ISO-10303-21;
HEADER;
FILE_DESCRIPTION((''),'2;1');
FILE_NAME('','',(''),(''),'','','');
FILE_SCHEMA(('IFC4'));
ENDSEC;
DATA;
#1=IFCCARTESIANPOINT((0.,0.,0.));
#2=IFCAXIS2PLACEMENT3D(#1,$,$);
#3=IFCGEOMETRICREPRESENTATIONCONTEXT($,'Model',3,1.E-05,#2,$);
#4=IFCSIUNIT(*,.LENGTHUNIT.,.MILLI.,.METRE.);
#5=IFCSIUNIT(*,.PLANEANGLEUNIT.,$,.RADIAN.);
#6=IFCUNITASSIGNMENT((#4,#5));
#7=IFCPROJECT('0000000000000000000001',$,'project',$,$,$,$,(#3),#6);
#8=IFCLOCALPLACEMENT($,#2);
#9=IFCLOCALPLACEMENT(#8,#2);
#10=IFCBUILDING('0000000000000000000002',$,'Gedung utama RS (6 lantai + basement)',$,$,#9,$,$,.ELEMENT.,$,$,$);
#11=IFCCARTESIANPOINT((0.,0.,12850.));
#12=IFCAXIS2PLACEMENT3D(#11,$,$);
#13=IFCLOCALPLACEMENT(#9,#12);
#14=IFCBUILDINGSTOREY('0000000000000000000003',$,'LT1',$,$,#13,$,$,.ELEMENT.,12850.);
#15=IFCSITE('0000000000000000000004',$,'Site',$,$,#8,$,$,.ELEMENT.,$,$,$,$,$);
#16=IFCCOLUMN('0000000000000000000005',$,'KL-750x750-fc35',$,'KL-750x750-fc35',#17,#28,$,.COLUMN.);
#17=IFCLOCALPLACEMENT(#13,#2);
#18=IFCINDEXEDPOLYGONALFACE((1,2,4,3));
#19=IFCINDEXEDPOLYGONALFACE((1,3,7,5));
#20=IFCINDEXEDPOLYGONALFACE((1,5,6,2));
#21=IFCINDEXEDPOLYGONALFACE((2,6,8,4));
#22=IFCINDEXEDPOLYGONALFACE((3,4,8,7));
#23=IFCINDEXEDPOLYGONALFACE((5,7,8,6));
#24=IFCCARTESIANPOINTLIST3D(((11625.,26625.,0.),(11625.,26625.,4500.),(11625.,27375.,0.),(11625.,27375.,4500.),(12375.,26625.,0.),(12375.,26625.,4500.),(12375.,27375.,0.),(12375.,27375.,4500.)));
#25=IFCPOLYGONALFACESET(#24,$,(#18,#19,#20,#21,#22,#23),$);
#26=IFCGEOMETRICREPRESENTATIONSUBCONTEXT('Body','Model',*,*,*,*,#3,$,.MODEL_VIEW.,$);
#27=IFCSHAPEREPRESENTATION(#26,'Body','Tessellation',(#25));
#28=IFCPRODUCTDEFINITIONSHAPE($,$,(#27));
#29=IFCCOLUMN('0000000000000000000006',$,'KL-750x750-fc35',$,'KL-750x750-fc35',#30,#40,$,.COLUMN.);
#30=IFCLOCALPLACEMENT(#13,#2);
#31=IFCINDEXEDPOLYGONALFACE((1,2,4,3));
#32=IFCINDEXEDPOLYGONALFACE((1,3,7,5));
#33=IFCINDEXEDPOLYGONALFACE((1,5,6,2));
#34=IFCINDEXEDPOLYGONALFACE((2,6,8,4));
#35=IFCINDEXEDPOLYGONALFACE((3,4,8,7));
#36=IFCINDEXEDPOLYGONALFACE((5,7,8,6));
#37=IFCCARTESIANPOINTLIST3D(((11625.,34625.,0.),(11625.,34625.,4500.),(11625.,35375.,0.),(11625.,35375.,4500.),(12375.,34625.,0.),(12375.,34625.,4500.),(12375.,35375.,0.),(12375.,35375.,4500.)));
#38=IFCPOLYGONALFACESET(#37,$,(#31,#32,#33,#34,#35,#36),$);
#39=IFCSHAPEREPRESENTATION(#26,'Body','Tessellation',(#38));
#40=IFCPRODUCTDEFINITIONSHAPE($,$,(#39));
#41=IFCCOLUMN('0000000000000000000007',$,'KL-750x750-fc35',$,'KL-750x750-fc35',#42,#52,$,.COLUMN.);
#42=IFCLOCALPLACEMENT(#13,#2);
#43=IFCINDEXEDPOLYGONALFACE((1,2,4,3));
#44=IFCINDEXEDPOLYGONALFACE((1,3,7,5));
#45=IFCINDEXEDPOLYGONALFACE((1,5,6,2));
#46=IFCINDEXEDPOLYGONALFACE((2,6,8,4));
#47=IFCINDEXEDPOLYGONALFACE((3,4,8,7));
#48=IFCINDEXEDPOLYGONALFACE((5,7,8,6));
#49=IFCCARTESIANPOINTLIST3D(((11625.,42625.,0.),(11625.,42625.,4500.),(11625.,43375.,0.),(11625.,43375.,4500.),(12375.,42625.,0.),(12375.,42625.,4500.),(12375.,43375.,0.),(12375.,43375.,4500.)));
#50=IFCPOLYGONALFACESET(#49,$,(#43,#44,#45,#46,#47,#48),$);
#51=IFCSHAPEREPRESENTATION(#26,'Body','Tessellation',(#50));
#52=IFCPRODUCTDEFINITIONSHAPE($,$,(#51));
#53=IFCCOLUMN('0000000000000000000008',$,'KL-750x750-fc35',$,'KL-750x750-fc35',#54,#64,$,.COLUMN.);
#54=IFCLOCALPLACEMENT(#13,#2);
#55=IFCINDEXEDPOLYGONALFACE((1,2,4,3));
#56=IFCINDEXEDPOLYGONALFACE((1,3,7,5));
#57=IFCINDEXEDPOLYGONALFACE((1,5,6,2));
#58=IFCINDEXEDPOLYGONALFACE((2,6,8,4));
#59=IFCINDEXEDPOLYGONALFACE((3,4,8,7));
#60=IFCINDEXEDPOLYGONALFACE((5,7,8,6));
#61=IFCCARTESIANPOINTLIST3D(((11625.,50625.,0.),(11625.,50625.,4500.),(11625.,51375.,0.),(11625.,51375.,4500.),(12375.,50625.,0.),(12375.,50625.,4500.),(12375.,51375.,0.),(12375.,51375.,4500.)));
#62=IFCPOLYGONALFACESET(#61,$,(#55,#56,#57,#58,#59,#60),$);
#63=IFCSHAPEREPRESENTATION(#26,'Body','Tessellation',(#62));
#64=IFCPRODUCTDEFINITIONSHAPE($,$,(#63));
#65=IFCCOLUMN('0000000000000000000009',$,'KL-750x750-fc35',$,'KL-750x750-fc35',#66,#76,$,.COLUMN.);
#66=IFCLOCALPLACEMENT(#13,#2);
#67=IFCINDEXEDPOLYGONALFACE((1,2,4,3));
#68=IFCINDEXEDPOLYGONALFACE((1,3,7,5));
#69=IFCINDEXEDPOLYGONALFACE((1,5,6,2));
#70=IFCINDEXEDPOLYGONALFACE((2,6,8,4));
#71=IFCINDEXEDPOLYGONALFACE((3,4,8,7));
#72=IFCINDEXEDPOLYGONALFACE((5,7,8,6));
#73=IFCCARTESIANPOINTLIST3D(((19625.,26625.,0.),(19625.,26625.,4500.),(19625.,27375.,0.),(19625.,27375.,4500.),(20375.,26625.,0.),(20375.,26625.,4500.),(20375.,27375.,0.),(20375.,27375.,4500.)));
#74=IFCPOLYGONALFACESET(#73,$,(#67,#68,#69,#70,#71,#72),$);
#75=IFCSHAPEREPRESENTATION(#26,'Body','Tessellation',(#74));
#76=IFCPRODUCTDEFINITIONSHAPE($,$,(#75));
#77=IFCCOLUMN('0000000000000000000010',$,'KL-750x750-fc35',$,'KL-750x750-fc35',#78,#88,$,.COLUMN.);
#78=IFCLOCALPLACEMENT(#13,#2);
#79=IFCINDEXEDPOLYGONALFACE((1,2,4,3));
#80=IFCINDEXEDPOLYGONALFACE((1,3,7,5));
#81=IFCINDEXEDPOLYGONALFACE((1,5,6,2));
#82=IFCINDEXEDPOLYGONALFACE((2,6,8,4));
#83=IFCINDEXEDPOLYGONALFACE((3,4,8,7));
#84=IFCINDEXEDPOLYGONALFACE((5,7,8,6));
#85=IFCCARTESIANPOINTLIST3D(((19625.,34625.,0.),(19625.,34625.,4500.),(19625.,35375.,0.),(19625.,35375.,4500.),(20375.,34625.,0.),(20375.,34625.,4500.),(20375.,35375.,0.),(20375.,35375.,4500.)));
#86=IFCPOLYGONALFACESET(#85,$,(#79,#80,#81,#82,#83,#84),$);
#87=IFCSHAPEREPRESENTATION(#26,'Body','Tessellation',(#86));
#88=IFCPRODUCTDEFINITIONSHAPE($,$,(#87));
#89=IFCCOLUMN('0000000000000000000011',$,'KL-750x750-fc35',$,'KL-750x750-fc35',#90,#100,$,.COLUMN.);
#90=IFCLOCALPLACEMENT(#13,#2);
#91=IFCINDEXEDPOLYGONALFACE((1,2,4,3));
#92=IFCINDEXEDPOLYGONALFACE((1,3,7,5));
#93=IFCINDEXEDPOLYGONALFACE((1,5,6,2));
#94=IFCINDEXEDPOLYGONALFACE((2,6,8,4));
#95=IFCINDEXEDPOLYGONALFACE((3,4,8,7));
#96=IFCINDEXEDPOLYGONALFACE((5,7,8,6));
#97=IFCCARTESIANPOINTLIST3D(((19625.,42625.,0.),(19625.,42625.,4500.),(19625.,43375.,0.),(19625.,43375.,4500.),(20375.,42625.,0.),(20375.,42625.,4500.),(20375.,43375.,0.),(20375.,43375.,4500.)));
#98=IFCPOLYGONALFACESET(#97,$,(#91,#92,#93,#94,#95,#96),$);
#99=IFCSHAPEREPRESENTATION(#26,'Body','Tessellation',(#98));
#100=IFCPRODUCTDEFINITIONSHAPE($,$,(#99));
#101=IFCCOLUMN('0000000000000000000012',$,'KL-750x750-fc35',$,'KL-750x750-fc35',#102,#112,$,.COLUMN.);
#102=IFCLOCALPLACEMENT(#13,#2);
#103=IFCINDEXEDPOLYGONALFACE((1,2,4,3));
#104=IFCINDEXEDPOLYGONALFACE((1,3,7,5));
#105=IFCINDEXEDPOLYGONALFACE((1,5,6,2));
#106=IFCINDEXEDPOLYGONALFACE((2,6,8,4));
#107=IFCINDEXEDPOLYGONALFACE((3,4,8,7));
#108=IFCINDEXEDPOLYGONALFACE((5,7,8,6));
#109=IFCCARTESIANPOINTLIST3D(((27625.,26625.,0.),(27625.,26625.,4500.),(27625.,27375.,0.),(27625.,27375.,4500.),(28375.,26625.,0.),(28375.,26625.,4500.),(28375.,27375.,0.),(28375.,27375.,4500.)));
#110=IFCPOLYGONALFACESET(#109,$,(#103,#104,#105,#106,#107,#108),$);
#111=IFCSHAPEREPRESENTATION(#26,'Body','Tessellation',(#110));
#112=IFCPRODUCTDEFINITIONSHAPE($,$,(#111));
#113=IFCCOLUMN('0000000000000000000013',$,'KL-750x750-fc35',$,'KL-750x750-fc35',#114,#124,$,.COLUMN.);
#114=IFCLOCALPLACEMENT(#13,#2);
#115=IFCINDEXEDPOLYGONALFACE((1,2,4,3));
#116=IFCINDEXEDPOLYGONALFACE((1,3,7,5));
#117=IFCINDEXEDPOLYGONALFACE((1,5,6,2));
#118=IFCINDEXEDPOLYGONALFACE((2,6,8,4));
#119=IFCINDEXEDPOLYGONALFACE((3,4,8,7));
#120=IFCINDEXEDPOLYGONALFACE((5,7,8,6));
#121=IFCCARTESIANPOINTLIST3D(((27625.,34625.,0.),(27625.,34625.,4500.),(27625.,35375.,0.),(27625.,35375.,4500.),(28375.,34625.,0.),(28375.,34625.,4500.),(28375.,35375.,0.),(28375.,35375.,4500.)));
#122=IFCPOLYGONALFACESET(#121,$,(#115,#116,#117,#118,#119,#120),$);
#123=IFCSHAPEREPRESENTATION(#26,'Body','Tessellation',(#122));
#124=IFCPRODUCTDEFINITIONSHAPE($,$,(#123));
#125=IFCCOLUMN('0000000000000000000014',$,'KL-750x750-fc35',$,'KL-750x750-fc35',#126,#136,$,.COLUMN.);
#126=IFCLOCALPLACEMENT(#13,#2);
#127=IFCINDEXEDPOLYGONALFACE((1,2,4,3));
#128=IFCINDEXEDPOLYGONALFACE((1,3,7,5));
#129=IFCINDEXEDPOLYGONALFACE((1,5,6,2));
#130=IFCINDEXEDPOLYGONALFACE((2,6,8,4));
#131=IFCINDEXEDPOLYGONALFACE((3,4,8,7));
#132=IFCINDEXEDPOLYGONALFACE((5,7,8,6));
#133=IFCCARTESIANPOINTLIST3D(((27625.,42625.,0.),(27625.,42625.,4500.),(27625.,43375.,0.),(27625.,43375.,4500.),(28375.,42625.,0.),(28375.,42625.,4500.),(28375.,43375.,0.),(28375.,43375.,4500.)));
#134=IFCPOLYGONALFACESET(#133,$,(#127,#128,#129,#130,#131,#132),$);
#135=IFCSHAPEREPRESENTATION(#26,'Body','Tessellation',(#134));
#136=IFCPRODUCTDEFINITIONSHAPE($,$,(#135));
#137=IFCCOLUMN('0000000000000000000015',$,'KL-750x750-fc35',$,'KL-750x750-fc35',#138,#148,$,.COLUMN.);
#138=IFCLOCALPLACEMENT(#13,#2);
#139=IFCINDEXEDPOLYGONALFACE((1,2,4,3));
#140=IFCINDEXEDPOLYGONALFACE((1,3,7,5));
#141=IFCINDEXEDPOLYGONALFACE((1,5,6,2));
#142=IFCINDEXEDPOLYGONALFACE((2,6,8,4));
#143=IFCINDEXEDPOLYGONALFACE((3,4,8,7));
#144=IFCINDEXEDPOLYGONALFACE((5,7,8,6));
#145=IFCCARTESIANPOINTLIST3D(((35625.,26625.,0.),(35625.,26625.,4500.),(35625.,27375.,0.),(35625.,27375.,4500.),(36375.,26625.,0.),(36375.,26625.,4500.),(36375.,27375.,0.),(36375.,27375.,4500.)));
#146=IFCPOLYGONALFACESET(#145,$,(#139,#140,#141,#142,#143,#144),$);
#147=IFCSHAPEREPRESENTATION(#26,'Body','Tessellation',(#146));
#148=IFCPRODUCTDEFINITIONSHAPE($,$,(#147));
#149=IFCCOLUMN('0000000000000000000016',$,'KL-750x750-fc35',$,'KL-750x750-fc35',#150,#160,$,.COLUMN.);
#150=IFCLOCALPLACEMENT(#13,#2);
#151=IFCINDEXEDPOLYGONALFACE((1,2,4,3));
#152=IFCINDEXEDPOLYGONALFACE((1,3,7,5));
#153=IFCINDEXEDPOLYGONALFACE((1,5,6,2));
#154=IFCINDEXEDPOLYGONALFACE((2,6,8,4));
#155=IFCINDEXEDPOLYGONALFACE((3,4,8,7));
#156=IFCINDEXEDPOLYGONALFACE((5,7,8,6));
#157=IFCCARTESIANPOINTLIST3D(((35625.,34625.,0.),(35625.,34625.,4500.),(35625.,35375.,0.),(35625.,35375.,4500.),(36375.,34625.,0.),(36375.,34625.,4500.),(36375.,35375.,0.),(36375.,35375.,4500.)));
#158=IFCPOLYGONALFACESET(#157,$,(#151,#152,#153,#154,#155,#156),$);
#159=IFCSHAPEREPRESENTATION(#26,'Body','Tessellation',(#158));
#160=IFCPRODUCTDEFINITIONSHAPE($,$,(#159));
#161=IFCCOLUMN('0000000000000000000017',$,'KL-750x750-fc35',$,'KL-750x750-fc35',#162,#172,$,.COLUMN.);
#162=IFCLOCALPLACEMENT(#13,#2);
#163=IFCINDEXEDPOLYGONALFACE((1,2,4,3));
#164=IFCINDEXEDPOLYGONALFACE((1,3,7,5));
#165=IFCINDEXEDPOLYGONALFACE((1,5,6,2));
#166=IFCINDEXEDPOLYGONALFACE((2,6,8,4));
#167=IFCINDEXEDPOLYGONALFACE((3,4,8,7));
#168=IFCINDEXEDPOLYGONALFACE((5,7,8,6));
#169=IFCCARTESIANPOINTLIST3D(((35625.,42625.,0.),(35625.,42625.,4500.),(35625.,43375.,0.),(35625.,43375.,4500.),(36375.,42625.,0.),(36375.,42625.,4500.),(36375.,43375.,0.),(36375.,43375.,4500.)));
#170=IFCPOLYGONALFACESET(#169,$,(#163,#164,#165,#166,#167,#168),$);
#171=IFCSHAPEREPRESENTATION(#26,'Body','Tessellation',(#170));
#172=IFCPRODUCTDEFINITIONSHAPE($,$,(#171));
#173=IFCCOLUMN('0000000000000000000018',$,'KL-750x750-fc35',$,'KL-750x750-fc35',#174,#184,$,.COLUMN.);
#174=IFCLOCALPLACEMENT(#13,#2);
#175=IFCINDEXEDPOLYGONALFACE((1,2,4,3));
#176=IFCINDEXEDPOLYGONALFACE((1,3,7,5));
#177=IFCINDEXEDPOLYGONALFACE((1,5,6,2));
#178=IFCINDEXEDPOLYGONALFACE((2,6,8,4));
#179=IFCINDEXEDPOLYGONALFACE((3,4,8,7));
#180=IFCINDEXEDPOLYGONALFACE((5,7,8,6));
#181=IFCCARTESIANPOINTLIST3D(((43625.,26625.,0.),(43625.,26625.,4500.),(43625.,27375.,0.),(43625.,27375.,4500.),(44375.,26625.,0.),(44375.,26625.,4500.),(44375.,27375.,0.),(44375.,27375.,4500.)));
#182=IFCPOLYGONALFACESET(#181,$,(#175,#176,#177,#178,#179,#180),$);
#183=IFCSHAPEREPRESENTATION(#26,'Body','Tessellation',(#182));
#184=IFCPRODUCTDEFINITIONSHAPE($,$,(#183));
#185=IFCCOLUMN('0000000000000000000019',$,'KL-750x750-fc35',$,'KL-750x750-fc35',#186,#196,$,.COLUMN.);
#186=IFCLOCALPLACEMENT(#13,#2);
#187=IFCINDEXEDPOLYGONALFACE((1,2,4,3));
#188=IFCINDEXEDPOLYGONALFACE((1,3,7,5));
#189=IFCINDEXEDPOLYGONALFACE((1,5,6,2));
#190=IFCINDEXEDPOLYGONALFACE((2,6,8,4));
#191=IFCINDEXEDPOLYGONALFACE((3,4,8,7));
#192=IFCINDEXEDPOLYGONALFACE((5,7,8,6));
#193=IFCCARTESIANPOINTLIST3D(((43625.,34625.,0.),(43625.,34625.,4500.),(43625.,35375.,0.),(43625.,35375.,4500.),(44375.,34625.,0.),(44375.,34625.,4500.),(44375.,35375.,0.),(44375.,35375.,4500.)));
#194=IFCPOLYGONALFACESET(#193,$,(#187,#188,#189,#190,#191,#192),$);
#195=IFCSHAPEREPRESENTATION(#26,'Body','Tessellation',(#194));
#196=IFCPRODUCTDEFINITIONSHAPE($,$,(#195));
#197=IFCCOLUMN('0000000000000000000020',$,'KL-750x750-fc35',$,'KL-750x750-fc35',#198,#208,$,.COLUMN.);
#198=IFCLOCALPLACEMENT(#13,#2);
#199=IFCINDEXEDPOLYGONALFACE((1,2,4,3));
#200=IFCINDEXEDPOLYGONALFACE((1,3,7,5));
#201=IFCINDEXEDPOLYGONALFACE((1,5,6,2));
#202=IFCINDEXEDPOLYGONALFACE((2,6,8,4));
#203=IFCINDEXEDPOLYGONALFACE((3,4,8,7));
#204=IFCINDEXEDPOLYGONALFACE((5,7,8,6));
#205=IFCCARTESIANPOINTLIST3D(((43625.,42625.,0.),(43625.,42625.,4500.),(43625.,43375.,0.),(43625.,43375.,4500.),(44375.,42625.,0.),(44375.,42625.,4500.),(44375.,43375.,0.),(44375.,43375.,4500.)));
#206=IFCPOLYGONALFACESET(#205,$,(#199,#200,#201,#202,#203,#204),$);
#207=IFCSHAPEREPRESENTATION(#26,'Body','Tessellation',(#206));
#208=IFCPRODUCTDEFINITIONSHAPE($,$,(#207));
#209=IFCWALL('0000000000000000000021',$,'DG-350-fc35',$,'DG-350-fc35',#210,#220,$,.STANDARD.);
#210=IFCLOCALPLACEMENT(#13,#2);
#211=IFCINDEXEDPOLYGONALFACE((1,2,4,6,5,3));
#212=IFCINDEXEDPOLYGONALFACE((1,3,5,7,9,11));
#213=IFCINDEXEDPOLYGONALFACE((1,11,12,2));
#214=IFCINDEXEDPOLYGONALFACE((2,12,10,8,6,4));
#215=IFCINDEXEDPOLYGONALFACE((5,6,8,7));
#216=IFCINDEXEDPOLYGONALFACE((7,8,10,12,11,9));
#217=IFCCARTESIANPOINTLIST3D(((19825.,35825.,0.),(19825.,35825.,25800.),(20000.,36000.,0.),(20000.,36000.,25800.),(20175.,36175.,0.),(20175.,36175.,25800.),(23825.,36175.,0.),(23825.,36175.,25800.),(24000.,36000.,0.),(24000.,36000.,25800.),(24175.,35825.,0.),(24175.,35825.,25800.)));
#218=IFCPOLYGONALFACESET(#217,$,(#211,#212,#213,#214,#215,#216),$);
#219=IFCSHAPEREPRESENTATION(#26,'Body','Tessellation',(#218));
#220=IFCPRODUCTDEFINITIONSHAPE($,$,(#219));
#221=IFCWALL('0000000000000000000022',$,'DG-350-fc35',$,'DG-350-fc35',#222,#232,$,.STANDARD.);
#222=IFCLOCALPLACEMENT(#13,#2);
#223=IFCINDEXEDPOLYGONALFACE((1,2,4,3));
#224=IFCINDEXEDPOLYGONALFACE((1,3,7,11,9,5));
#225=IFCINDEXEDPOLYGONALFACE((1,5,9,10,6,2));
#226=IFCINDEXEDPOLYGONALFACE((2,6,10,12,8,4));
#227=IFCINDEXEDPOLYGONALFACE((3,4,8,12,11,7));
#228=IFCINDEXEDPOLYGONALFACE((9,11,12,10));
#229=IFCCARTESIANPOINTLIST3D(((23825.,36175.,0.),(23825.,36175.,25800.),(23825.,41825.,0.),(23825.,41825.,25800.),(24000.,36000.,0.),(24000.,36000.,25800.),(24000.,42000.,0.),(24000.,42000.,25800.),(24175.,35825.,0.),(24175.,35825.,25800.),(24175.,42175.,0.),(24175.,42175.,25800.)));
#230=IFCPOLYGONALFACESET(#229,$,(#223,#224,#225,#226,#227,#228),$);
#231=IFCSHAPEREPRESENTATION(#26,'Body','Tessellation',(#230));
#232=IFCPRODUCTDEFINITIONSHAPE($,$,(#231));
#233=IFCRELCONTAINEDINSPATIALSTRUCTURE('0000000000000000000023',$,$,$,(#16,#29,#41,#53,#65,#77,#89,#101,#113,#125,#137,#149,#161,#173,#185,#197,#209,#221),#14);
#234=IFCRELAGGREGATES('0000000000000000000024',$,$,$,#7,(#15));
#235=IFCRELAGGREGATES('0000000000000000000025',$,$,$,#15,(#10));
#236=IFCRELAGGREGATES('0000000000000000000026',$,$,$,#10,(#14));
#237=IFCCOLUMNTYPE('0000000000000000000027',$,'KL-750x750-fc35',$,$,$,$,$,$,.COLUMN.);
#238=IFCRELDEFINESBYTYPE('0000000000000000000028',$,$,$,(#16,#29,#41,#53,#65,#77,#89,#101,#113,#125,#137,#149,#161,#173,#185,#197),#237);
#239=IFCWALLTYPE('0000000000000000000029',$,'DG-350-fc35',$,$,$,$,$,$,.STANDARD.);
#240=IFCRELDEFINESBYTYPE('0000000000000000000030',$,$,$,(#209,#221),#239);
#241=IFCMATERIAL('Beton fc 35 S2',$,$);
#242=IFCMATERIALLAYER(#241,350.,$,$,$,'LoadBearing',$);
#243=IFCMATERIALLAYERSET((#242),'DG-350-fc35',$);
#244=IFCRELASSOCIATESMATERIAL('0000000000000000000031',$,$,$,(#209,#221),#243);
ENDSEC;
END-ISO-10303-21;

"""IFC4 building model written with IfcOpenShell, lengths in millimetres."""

from ifc_helpers import new_model, si_unit, frame, origin, origin_2d, place, context, subcontext, project, spatial, polyline, rectangle, outline, extrude, material, layer, layer_set, layer_usage, material_profile, profile_set, profile_usage, type_object, element, save


model = new_model("IFC4")

# Units and contexts
model_context = context("Model", 3, precision=1e-05, world=origin())
body_context = subcontext(model_context, "Body", "Model", "MODEL_VIEW")
ifc_project = project(units=[si_unit("LENGTHUNIT", "METRE", prefix="MILLI"), si_unit("PLANEANGLEUNIT", "RADIAN")], contexts=[model_context])

# Site, building, storey
site_placement = place(None, origin())
site = spatial("IfcSite", under=ifc_project, at=site_placement, Name="Site", CompositionType="ELEMENT")
building_placement = place(site_placement, origin())
building = spatial("IfcBuilding", under=site, at=building_placement, Name="Gedung utama RS (6 lantai + basement)", CompositionType="ELEMENT")
storey_placement = place(building_placement, frame((0.0, 0.0, 12850.0)))
storey = spatial("IfcBuildingStorey", under=building, at=storey_placement, Name="LT1", CompositionType="ELEMENT", Elevation=12850.0)

# Columns
ifc_material_profile = material_profile(None, rectangle(XDim=750.0, YDim=750.0, at=origin_2d()), Name="KL-750x750-fc35")
ifc_profile_set = profile_set([ifc_material_profile], Name="KL-750x750-fc35")
ifc_profile_usage = profile_usage(ifc_profile_set, cardinal=5)
column_type = type_object("IfcColumnType", Name="KL-750x750-fc35", PredefinedType="COLUMN", material=ifc_profile_set)
for number, where, z_axis, x_axis, name in (
    (1, (12000.0, 27000.0, 0.0), (0.0, 0.0, 1.0), (1.0, 0.0, 0.0), "KL-750x750-fc35"),
    (2, (12000.0, 35000.0, 0.0), (0.0, 0.0, 1.0), (1.0, 0.0, 0.0), "KL-750x750-fc35"),
    (3, (12000.0, 43000.0, 0.0), (0.0, 0.0, 1.0), (1.0, 0.0, 0.0), "KL-750x750-fc35"),
    (4, (12000.0, 51000.0, 0.0), (0.0, 0.0, 1.0), (1.0, 0.0, 0.0), "KL-750x750-fc35"),
    (5, (20000.0, 27000.0, 0.0), (0.0, 0.0, 1.0), (1.0, 0.0, 0.0), "KL-750x750-fc35"),
    (6, (20000.0, 35000.0, 0.0), (0.0, 0.0, 1.0), (1.0, 0.0, 0.0), "KL-750x750-fc35"),
    (7, (20000.0, 43000.0, 0.0), (0.0, 0.0, 1.0), (1.0, 0.0, 0.0), "KL-750x750-fc35"),
    (8, (28000.0, 27000.0, 0.0), (0.0, 0.0, 1.0), (1.0, 0.0, 0.0), "KL-750x750-fc35"),
    (9, (28000.0, 35000.0, 0.0), (0.0, 0.0, 1.0), (1.0, 0.0, 0.0), "KL-750x750-fc35"),
    (10, (28000.0, 43000.0, 0.0), (0.0, 0.0, 1.0), (1.0, 0.0, 0.0), "KL-750x750-fc35"),
    (11, (36000.0, 27000.0, 0.0), (0.0, 0.0, 1.0), (1.0, 0.0, 0.0), "KL-750x750-fc35"),
    (12, (36000.0, 35000.0, 0.0), (0.0, 0.0, 1.0), (1.0, 0.0, 0.0), "KL-750x750-fc35"),
    (13, (36000.0, 43000.0, 0.0), (0.0, 0.0, 1.0), (1.0, 0.0, 0.0), "KL-750x750-fc35"),
    (14, (44000.0, 27000.0, 0.0), (0.0, 0.0, 1.0), (1.0, 0.0, 0.0), "KL-750x750-fc35"),
    (15, (44000.0, 35000.0, 0.0), (0.0, 0.0, 1.0), (1.0, 0.0, 0.0), "KL-750x750-fc35"),
    (16, (44000.0, 43000.0, 0.0), (0.0, 0.0, 1.0), (1.0, 0.0, 0.0), "KL-750x750-fc35"),
):
    element("IfcColumn", number, at=place(storey_placement, frame(where, z_axis=z_axis, x_axis=x_axis)), inside=storey, type_object=column_type, material=ifc_profile_usage, Name=name, ObjectType="KL-750x750-fc35", PredefinedType="COLUMN", context=body_context, shape_type="SweptSolid", body=[
        extrude(rectangle(XDim=750.0, YDim=750.0, at=origin_2d()), origin(), (0.0, 0.0, 1.0), 4500.0),
    ])

# Walls
ifc_material = material(Name="Beton fc 35 S2")
ifc_layer = layer(ifc_material, 350.0, Category="LoadBearing")
ifc_layer_set = layer_set([ifc_layer], Name="DG-350-fc35")
ifc_layer_usage = layer_usage(ifc_layer_set, "AXIS2", "NEGATIVE", 175.0)
wall_type = type_object("IfcWallType", Name="DG-350-fc35", PredefinedType="STANDARD")
wall_1_placement = place(storey_placement, frame((20000.0, 36000.0, 0.0), z_axis=(0.0, 0.0, 1.0), x_axis=(1.0, 0.0, 0.0)))
element("IfcWall", 17, at=wall_1_placement, inside=storey, type_object=wall_type, material=ifc_layer_usage, Name="DG-350-fc35", ObjectType="DG-350-fc35", PredefinedType="STANDARD", context=body_context, shape_type="SweptSolid", body=[
    extrude(outline(polyline([(-175.0, -175.0), (0.0, 0.0), (175.0, 175.0), (3825.0, 175.0), (4000.0, 0.0), (4175.0, -175.0), (-175.0, -175.0)])), origin(), (0.0, 0.0, 1.0), 25800.0),
])
wall_2_placement = place(storey_placement, frame((24000.0, 36000.0, 0.0), z_axis=(0.0, 0.0, 1.0), x_axis=(0.0, 1.0, 0.0)))
element("IfcWall", 18, at=wall_2_placement, inside=storey, type_object=wall_type, material=ifc_layer_usage, Name="DG-350-fc35", ObjectType="DG-350-fc35", PredefinedType="STANDARD", context=body_context, shape_type="SweptSolid", body=[
    extrude(outline(polyline([(-175.0, -175.0), (0.0, 0.0), (175.0, 175.0), (5825.0, 175.0), (6000.0, 0.0), (6175.0, -175.0), (-175.0, -175.0)])), origin(), (0.0, 0.0, 1.0), 25800.0),
])

save(model, "model.ifc")
